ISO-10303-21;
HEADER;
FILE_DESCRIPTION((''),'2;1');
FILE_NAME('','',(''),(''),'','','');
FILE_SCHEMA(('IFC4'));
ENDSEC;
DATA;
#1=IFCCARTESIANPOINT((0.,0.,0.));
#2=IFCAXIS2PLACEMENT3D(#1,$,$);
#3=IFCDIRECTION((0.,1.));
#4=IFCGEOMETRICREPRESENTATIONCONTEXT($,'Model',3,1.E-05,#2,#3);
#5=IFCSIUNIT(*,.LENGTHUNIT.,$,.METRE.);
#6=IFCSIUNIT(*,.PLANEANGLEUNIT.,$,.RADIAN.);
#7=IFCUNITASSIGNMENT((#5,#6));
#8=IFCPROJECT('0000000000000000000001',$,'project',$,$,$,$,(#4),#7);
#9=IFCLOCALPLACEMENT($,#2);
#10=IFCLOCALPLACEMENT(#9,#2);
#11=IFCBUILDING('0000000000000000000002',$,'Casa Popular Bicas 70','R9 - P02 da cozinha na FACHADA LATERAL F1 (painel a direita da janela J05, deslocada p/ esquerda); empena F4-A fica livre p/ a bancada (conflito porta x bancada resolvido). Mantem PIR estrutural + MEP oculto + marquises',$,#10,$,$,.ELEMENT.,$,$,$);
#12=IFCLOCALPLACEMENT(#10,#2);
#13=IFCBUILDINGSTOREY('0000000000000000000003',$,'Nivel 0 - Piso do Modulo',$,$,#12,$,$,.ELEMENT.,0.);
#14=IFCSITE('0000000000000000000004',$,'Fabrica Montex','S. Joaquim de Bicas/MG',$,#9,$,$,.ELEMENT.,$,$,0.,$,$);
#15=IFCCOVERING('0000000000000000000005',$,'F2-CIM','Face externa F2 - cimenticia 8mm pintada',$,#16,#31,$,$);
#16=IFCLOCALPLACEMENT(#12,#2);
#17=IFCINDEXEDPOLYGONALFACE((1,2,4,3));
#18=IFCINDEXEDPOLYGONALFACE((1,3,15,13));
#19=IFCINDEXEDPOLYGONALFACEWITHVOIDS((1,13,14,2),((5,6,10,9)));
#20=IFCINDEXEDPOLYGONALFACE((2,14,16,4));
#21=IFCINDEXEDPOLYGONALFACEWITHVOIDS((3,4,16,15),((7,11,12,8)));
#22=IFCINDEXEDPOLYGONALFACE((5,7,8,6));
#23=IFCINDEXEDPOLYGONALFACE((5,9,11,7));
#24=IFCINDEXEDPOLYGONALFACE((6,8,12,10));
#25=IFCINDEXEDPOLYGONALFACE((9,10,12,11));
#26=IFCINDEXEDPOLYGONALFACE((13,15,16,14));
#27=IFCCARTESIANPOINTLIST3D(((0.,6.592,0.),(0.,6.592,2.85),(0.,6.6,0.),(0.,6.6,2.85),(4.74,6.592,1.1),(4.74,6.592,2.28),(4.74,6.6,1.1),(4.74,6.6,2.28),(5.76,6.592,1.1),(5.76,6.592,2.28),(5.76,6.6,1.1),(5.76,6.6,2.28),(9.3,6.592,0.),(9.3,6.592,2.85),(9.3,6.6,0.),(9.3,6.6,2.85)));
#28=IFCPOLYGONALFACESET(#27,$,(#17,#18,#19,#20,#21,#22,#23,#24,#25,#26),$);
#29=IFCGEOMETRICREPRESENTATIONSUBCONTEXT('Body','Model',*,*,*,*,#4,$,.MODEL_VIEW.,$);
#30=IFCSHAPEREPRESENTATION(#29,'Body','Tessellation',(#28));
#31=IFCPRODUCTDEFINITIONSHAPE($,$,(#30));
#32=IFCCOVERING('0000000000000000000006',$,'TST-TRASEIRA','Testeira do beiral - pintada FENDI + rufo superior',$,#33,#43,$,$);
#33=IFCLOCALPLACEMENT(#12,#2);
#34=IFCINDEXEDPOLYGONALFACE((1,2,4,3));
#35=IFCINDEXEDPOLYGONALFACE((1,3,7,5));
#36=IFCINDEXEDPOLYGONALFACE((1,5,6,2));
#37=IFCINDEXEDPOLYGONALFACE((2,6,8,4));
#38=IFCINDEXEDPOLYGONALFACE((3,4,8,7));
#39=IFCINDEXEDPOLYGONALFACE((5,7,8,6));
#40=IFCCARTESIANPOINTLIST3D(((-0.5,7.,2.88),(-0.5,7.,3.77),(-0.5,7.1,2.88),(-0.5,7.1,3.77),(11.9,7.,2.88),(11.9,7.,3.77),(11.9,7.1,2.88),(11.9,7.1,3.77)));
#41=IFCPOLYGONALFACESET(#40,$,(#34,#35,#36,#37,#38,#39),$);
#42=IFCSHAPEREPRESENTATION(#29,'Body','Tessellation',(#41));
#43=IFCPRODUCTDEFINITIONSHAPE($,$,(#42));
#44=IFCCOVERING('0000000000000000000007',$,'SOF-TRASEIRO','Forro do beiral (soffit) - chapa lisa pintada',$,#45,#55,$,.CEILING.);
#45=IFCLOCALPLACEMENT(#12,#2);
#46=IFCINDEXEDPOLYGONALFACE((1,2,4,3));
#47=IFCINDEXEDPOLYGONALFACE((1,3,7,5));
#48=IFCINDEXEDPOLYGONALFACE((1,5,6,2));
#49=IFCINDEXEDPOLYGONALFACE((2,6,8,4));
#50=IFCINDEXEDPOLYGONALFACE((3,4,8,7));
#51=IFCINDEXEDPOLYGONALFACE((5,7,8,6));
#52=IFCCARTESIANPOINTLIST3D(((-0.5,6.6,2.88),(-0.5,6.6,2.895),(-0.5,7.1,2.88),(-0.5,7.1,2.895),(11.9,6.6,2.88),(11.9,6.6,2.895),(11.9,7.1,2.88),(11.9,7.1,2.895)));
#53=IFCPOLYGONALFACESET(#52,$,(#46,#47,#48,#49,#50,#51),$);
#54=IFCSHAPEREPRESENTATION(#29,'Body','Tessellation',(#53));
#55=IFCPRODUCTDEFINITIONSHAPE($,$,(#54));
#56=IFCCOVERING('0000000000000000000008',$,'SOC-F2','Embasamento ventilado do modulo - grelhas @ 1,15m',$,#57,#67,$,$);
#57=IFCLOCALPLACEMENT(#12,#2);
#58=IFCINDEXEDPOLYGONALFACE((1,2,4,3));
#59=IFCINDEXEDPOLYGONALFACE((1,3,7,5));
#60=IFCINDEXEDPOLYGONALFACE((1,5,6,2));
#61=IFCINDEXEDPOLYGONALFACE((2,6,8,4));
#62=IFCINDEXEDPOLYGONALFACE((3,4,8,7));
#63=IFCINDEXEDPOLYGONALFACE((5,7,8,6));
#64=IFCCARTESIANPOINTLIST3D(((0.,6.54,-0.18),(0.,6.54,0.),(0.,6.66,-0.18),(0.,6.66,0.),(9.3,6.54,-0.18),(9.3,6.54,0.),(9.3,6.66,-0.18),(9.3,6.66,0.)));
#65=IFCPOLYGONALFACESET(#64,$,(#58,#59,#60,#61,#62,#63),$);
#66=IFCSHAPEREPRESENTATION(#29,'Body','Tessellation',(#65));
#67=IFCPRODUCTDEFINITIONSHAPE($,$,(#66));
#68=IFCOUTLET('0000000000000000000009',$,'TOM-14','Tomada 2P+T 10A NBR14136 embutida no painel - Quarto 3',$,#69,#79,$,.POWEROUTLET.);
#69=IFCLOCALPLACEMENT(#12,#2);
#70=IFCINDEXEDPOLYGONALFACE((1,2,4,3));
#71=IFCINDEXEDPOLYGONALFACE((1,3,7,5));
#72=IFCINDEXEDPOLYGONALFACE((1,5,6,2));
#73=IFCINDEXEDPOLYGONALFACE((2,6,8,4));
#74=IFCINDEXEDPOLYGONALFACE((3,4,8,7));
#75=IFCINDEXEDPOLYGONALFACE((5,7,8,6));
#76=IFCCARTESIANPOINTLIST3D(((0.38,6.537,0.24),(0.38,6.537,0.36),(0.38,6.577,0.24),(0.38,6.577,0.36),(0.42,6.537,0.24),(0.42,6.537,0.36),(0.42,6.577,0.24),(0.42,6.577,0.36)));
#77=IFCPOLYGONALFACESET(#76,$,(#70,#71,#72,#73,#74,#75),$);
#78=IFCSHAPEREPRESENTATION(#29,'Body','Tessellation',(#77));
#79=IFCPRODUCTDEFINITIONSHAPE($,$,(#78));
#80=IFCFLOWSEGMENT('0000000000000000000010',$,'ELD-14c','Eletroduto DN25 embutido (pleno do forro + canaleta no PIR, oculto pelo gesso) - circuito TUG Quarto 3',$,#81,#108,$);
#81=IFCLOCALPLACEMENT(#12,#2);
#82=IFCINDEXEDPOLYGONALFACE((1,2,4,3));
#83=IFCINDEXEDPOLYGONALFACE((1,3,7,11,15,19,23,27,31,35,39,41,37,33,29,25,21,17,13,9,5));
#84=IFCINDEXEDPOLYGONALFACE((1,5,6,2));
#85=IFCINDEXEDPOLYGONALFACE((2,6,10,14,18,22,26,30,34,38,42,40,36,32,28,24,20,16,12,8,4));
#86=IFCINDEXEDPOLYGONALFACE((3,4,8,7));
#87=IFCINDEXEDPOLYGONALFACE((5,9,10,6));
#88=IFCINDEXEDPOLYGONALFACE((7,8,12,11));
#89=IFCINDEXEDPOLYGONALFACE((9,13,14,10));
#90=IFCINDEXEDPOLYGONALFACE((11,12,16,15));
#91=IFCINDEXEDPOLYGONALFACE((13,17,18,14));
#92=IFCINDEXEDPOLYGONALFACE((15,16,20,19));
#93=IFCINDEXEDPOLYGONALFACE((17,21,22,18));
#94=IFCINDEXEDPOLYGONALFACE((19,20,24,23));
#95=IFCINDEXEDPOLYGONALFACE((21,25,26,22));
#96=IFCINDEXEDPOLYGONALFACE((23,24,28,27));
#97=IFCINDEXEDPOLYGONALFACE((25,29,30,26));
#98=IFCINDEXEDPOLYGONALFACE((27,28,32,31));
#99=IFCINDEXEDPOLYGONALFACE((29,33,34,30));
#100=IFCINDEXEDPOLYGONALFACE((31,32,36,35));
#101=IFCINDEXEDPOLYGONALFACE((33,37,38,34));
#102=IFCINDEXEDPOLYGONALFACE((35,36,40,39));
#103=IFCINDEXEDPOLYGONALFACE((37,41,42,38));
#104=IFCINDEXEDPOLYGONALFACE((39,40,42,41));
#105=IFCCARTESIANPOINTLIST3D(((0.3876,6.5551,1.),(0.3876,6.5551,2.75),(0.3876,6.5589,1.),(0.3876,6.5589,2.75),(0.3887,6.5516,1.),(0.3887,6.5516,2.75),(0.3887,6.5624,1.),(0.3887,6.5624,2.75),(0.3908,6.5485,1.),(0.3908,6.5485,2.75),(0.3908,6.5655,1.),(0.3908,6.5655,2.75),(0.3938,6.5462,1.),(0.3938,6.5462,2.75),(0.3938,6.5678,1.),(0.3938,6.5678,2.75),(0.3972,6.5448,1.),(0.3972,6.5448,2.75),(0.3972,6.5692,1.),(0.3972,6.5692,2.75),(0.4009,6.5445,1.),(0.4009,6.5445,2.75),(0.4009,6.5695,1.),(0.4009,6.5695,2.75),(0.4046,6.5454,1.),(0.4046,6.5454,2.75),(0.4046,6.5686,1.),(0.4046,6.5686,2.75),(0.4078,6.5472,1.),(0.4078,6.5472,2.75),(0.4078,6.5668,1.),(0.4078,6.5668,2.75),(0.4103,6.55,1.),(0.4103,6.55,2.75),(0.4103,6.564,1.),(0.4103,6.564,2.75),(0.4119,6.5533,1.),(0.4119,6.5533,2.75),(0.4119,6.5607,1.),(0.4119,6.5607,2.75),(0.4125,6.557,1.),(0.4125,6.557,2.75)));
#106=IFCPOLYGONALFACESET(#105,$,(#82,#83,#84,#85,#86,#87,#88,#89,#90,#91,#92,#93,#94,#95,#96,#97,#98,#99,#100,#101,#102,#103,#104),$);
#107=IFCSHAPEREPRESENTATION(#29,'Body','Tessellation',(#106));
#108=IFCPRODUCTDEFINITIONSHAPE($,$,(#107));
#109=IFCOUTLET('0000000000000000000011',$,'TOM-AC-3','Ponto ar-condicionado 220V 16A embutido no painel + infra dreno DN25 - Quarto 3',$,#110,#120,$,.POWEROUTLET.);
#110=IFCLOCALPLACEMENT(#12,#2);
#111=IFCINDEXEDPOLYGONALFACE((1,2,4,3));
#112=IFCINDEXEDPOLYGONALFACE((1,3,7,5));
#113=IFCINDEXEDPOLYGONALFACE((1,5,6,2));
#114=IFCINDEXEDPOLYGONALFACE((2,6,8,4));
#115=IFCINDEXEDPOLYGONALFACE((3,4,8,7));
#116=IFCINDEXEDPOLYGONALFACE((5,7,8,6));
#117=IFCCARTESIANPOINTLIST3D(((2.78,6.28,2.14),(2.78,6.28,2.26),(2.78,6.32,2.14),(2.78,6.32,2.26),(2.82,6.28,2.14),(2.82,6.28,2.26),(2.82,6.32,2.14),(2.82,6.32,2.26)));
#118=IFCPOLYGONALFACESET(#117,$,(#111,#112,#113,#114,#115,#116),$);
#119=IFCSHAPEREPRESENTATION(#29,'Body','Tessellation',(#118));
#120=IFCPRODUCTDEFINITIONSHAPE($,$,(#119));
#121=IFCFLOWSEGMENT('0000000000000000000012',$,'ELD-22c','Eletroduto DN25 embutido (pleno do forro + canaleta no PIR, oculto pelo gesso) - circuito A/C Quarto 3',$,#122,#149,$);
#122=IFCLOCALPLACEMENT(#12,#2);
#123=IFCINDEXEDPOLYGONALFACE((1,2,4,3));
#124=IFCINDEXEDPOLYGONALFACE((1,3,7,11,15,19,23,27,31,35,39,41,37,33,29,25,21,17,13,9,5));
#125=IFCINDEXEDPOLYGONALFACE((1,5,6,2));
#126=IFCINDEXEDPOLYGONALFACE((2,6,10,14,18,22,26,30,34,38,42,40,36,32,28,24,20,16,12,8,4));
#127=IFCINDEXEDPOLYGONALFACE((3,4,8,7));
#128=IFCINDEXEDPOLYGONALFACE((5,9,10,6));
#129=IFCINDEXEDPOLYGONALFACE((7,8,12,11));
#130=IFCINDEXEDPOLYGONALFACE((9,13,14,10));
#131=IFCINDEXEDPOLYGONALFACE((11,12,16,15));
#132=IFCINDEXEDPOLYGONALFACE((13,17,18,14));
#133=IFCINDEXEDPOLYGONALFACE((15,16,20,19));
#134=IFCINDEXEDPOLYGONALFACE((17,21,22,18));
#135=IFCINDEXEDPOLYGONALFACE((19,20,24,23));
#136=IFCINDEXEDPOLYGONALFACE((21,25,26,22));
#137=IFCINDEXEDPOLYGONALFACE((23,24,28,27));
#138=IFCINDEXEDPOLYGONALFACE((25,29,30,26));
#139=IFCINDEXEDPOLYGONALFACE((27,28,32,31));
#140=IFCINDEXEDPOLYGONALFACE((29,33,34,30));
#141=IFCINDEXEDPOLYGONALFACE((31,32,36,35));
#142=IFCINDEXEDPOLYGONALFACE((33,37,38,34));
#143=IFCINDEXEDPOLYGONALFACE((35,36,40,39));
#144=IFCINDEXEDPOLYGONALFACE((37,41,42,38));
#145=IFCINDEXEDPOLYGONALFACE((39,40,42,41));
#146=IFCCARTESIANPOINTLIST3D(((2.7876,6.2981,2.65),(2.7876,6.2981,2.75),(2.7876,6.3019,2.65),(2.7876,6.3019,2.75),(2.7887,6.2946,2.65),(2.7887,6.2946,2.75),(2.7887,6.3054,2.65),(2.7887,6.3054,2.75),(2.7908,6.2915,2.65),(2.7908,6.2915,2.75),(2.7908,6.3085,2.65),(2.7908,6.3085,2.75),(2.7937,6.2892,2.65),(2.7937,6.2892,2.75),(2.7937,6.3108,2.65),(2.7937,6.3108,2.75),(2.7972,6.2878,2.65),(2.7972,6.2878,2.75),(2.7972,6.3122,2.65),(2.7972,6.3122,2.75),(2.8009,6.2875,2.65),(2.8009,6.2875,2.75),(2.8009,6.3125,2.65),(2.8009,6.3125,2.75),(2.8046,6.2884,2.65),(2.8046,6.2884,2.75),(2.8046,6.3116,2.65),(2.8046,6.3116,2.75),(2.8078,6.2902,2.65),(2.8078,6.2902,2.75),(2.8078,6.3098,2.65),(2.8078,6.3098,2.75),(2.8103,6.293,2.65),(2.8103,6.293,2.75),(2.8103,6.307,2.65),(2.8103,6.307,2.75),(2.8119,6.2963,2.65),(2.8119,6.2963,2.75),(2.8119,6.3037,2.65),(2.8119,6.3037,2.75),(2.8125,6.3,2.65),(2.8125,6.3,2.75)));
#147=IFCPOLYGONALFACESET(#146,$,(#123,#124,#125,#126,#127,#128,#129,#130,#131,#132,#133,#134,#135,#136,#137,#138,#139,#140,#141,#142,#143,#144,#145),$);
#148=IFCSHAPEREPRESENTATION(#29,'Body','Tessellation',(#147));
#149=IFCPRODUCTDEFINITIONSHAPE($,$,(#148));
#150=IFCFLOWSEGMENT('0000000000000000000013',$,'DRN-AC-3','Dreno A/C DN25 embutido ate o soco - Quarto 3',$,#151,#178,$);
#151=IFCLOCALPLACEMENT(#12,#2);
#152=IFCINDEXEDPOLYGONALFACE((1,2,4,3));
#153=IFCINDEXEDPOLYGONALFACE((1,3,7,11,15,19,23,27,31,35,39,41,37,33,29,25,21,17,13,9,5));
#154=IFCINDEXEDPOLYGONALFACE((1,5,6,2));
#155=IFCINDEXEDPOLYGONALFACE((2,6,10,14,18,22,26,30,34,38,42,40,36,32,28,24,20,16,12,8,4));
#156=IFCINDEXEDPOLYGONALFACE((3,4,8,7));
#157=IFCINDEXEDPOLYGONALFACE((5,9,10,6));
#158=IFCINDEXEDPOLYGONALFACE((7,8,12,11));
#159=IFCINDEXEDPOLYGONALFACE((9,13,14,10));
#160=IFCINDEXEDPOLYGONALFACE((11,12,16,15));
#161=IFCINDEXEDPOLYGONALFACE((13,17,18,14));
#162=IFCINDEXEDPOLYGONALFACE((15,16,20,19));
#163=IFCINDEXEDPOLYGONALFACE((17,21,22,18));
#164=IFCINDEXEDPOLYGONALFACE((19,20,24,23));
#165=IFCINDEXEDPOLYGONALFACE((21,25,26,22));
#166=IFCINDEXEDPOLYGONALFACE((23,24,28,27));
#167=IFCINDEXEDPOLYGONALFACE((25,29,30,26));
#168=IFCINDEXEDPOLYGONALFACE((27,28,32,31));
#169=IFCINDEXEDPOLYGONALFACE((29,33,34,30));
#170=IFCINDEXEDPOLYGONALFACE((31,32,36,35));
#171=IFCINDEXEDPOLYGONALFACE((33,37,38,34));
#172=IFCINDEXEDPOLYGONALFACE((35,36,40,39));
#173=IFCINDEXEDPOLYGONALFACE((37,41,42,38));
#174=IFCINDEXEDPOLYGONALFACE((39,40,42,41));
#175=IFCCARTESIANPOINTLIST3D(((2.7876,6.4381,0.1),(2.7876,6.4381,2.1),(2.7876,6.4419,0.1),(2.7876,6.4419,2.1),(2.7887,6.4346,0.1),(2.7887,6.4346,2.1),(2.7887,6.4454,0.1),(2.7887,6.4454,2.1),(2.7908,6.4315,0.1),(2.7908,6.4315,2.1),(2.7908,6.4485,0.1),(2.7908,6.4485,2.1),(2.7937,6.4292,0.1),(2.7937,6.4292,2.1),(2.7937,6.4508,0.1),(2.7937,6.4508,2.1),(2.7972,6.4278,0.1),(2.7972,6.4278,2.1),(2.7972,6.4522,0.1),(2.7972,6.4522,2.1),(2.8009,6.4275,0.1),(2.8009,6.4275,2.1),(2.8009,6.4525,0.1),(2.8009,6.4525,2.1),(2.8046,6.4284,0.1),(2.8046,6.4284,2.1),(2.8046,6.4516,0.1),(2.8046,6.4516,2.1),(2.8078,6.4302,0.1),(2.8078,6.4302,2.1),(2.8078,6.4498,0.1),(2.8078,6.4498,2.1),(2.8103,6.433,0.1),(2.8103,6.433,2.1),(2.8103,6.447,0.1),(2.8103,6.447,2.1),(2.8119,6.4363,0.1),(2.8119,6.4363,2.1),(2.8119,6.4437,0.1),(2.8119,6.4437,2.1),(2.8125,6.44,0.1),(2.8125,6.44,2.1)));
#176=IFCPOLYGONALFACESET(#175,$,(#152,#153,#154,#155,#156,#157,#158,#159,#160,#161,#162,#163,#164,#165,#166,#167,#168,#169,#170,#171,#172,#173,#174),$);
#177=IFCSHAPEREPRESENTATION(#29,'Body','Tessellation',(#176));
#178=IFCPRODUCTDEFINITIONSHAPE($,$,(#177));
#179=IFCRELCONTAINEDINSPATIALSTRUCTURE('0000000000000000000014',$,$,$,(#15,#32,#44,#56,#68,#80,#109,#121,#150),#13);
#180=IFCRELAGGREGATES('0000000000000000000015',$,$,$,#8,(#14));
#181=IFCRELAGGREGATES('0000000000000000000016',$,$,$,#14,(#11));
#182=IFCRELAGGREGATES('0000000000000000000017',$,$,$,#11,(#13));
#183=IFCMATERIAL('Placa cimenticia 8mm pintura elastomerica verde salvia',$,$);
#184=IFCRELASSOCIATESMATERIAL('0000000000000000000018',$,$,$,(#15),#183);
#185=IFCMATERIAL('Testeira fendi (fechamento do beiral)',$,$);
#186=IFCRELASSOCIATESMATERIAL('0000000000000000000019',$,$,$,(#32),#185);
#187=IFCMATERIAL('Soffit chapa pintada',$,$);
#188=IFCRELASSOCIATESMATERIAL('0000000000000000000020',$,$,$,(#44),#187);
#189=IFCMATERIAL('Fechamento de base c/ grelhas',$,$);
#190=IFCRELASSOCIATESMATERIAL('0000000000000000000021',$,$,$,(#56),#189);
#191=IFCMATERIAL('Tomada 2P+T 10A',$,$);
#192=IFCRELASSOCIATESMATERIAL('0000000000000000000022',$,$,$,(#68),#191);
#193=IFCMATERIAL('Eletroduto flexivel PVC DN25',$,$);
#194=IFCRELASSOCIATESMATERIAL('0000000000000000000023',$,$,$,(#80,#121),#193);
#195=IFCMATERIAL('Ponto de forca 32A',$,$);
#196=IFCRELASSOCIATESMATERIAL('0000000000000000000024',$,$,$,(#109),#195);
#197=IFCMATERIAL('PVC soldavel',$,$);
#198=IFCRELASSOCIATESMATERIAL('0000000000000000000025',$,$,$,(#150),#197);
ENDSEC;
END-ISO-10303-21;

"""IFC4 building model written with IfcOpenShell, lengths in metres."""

from ifc_helpers import new_model, si_unit, direction, frame, frame_2d, origin, origin_2d, place, context, subcontext, project, spatial, rectangle, circle, extrude, material, element, save


model = new_model("IFC4")

# Units and contexts
model_context = context("Model", 3, precision=1e-05, world=origin(), true_north=direction((0.0, 1.0)))
body_context = subcontext(model_context, "Body", "Model", "MODEL_VIEW")
ifc_project = project(units=[si_unit("LENGTHUNIT", "METRE"), si_unit("PLANEANGLEUNIT", "RADIAN")], contexts=[model_context])

# Site, building, storey
site_placement = place(None, origin())
site = spatial("IfcSite", under=ifc_project, at=site_placement, Name="Fabrica Montex", Description="S. Joaquim de Bicas/MG", CompositionType="ELEMENT", RefElevation=0.0)
building_placement = place(site_placement, origin())
building = spatial("IfcBuilding", under=site, at=building_placement, Name="Casa Popular Bicas 70", Description="R9 - P02 da cozinha na FACHADA LATERAL F1 (painel a direita da janela J05, deslocada p/ esquerda); empena F4-A fica livre p/ a bancada (conflito porta x bancada resolvido). Mantem PIR estrutural + MEP oculto + marquises", CompositionType="ELEMENT")
storey_placement = place(building_placement, origin())
storey = spatial("IfcBuildingStorey", under=building, at=storey_placement, Name="Nivel 0 - Piso do Modulo", CompositionType="ELEMENT", Elevation=0.0)

# Covering, opening
ifc_material_1 = material(Name="Placa cimenticia 8mm pintura elastomerica verde salvia")
covering_1_placement = place(storey_placement, frame((0.0, 6.596, 0.0), x_axis=(1.0, 0.0, 0.0)))
covering_1 = element("IfcCovering", 1, at=covering_1_placement, inside=storey, material=ifc_material_1, Name="F2-CIM", Description="Face externa F2 - cimenticia 8mm pintada", context=body_context, shape_type="SweptSolid", body=[
    extrude(rectangle(XDim=9.3, YDim=0.008, at=frame_2d((4.65, 0.0))), origin(), (0.0, 0.0, 1.0), 2.85),
])
opening_1_placement = place(storey_placement, frame((4.75, 6.596, 1.1)))
element("IfcOpeningElement", 2, at=opening_1_placement, cuts=covering_1, PredefinedType="OPENING", context=body_context, shape_type="SweptSolid", body=[
    extrude(rectangle(XDim=1.02, YDim=0.03, at=frame_2d((0.5, 0.0))), origin(), (0.0, 0.0, 1.0), 1.18),
])

# Coverings
ifc_material_2 = material(Name="Testeira fendi (fechamento do beiral)")
covering_2_placement = place(storey_placement, frame((-0.5, 7.05, 2.88), x_axis=(1.0, 0.0, 0.0)))
element("IfcCovering", 3, at=covering_2_placement, inside=storey, material=ifc_material_2, Name="TST-TRASEIRA", Description="Testeira do beiral - pintada FENDI + rufo superior", context=body_context, shape_type="SweptSolid", body=[
    extrude(rectangle(XDim=12.4, YDim=0.1, at=frame_2d((6.2, 0.0))), origin(), (0.0, 0.0, 1.0), 0.89),
])
ifc_material_3 = material(Name="Soffit chapa pintada")
covering_3_placement = place(storey_placement, frame((-0.5, 6.6, 2.88)))
element("IfcCovering", 4, at=covering_3_placement, inside=storey, material=ifc_material_3, Name="SOF-TRASEIRO", Description="Forro do beiral (soffit) - chapa lisa pintada", PredefinedType="CEILING", context=body_context, shape_type="SweptSolid", body=[
    extrude(rectangle(XDim=12.4, YDim=0.5, at=frame_2d((6.2, 0.25))), origin(), (0.0, 0.0, 1.0), 0.015),
])
ifc_material_4 = material(Name="Fechamento de base c/ grelhas")
covering_4_placement = place(storey_placement, frame((0.0, 6.6, -0.18), x_axis=(1.0, 0.0, 0.0)))
element("IfcCovering", 5, at=covering_4_placement, inside=storey, material=ifc_material_4, Name="SOC-F2", Description="Embasamento ventilado do modulo - grelhas @ 1,15m", context=body_context, shape_type="SweptSolid", body=[
    extrude(rectangle(XDim=9.3, YDim=0.12, at=frame_2d((4.65, 0.0))), origin(), (0.0, 0.0, 1.0), 0.18),
])

# Outlet
ifc_material_5 = material(Name="Tomada 2P+T 10A")
outlet_1_placement = place(storey_placement, frame((0.38, 6.537, 0.24)))
element("IfcOutlet", 6, at=outlet_1_placement, inside=storey, material=ifc_material_5, Name="TOM-14", Description="Tomada 2P+T 10A NBR14136 embutida no painel - Quarto 3", PredefinedType="POWEROUTLET", context=body_context, shape_type="SweptSolid", body=[
    extrude(rectangle(XDim=0.04, YDim=0.04, at=frame_2d((0.02, 0.02))), origin(), (0.0, 0.0, 1.0), 0.12),
])

# Flow segment
ifc_material_6 = material(Name="Eletroduto flexivel PVC DN25")
flow_segment_1_placement = place(storey_placement, frame((0.4, 6.557, 2.75), z_axis=(0.0, 0.0, -1.0), x_axis=(1.0, 0.0, 0.0)))
element("IfcFlowSegment", 7, at=flow_segment_1_placement, inside=storey, material=ifc_material_6, Name="ELD-14c", Description="Eletroduto DN25 embutido (pleno do forro + canaleta no PIR, oculto pelo gesso) - circuito TUG Quarto 3", context=body_context, shape_type="SweptSolid", body=[
    extrude(circle(Radius=0.0125, at=origin_2d()), origin(), (0.0, 0.0, 1.0), 1.75),
])

# Outlet
ifc_material_7 = material(Name="Ponto de forca 32A")
outlet_2_placement = place(storey_placement, frame((2.78, 6.28, 2.14)))
element("IfcOutlet", 8, at=outlet_2_placement, inside=storey, material=ifc_material_7, Name="TOM-AC-3", Description="Ponto ar-condicionado 220V 16A embutido no painel + infra dreno DN25 - Quarto 3", PredefinedType="POWEROUTLET", context=body_context, shape_type="SweptSolid", body=[
    extrude(rectangle(XDim=0.04, YDim=0.04, at=frame_2d((0.02, 0.02))), origin(), (0.0, 0.0, 1.0), 0.12),
])

# Flow segments
flow_segment_2_placement = place(storey_placement, frame((2.8, 6.3, 2.75), z_axis=(0.0, 0.0, -1.0), x_axis=(1.0, 0.0, 0.0)))
element("IfcFlowSegment", 9, at=flow_segment_2_placement, inside=storey, material=ifc_material_6, Name="ELD-22c", Description="Eletroduto DN25 embutido (pleno do forro + canaleta no PIR, oculto pelo gesso) - circuito A/C Quarto 3", context=body_context, shape_type="SweptSolid", body=[
    extrude(circle(Radius=0.0125, at=origin_2d()), origin(), (0.0, 0.0, 1.0), 0.1),
])
ifc_material_8 = material(Name="PVC soldavel")
flow_segment_3_placement = place(storey_placement, frame((2.8, 6.44, 2.1), z_axis=(0.0, 0.0, -1.0), x_axis=(1.0, 0.0, 0.0)))
element("IfcFlowSegment", 10, at=flow_segment_3_placement, inside=storey, material=ifc_material_8, Name="DRN-AC-3", Description="Dreno A/C DN25 embutido ate o soco - Quarto 3", context=body_context, shape_type="SweptSolid", body=[
    extrude(circle(Radius=0.0125, at=origin_2d()), origin(), (0.0, 0.0, 1.0), 2.0),
])

save(model, "model.ifc")
